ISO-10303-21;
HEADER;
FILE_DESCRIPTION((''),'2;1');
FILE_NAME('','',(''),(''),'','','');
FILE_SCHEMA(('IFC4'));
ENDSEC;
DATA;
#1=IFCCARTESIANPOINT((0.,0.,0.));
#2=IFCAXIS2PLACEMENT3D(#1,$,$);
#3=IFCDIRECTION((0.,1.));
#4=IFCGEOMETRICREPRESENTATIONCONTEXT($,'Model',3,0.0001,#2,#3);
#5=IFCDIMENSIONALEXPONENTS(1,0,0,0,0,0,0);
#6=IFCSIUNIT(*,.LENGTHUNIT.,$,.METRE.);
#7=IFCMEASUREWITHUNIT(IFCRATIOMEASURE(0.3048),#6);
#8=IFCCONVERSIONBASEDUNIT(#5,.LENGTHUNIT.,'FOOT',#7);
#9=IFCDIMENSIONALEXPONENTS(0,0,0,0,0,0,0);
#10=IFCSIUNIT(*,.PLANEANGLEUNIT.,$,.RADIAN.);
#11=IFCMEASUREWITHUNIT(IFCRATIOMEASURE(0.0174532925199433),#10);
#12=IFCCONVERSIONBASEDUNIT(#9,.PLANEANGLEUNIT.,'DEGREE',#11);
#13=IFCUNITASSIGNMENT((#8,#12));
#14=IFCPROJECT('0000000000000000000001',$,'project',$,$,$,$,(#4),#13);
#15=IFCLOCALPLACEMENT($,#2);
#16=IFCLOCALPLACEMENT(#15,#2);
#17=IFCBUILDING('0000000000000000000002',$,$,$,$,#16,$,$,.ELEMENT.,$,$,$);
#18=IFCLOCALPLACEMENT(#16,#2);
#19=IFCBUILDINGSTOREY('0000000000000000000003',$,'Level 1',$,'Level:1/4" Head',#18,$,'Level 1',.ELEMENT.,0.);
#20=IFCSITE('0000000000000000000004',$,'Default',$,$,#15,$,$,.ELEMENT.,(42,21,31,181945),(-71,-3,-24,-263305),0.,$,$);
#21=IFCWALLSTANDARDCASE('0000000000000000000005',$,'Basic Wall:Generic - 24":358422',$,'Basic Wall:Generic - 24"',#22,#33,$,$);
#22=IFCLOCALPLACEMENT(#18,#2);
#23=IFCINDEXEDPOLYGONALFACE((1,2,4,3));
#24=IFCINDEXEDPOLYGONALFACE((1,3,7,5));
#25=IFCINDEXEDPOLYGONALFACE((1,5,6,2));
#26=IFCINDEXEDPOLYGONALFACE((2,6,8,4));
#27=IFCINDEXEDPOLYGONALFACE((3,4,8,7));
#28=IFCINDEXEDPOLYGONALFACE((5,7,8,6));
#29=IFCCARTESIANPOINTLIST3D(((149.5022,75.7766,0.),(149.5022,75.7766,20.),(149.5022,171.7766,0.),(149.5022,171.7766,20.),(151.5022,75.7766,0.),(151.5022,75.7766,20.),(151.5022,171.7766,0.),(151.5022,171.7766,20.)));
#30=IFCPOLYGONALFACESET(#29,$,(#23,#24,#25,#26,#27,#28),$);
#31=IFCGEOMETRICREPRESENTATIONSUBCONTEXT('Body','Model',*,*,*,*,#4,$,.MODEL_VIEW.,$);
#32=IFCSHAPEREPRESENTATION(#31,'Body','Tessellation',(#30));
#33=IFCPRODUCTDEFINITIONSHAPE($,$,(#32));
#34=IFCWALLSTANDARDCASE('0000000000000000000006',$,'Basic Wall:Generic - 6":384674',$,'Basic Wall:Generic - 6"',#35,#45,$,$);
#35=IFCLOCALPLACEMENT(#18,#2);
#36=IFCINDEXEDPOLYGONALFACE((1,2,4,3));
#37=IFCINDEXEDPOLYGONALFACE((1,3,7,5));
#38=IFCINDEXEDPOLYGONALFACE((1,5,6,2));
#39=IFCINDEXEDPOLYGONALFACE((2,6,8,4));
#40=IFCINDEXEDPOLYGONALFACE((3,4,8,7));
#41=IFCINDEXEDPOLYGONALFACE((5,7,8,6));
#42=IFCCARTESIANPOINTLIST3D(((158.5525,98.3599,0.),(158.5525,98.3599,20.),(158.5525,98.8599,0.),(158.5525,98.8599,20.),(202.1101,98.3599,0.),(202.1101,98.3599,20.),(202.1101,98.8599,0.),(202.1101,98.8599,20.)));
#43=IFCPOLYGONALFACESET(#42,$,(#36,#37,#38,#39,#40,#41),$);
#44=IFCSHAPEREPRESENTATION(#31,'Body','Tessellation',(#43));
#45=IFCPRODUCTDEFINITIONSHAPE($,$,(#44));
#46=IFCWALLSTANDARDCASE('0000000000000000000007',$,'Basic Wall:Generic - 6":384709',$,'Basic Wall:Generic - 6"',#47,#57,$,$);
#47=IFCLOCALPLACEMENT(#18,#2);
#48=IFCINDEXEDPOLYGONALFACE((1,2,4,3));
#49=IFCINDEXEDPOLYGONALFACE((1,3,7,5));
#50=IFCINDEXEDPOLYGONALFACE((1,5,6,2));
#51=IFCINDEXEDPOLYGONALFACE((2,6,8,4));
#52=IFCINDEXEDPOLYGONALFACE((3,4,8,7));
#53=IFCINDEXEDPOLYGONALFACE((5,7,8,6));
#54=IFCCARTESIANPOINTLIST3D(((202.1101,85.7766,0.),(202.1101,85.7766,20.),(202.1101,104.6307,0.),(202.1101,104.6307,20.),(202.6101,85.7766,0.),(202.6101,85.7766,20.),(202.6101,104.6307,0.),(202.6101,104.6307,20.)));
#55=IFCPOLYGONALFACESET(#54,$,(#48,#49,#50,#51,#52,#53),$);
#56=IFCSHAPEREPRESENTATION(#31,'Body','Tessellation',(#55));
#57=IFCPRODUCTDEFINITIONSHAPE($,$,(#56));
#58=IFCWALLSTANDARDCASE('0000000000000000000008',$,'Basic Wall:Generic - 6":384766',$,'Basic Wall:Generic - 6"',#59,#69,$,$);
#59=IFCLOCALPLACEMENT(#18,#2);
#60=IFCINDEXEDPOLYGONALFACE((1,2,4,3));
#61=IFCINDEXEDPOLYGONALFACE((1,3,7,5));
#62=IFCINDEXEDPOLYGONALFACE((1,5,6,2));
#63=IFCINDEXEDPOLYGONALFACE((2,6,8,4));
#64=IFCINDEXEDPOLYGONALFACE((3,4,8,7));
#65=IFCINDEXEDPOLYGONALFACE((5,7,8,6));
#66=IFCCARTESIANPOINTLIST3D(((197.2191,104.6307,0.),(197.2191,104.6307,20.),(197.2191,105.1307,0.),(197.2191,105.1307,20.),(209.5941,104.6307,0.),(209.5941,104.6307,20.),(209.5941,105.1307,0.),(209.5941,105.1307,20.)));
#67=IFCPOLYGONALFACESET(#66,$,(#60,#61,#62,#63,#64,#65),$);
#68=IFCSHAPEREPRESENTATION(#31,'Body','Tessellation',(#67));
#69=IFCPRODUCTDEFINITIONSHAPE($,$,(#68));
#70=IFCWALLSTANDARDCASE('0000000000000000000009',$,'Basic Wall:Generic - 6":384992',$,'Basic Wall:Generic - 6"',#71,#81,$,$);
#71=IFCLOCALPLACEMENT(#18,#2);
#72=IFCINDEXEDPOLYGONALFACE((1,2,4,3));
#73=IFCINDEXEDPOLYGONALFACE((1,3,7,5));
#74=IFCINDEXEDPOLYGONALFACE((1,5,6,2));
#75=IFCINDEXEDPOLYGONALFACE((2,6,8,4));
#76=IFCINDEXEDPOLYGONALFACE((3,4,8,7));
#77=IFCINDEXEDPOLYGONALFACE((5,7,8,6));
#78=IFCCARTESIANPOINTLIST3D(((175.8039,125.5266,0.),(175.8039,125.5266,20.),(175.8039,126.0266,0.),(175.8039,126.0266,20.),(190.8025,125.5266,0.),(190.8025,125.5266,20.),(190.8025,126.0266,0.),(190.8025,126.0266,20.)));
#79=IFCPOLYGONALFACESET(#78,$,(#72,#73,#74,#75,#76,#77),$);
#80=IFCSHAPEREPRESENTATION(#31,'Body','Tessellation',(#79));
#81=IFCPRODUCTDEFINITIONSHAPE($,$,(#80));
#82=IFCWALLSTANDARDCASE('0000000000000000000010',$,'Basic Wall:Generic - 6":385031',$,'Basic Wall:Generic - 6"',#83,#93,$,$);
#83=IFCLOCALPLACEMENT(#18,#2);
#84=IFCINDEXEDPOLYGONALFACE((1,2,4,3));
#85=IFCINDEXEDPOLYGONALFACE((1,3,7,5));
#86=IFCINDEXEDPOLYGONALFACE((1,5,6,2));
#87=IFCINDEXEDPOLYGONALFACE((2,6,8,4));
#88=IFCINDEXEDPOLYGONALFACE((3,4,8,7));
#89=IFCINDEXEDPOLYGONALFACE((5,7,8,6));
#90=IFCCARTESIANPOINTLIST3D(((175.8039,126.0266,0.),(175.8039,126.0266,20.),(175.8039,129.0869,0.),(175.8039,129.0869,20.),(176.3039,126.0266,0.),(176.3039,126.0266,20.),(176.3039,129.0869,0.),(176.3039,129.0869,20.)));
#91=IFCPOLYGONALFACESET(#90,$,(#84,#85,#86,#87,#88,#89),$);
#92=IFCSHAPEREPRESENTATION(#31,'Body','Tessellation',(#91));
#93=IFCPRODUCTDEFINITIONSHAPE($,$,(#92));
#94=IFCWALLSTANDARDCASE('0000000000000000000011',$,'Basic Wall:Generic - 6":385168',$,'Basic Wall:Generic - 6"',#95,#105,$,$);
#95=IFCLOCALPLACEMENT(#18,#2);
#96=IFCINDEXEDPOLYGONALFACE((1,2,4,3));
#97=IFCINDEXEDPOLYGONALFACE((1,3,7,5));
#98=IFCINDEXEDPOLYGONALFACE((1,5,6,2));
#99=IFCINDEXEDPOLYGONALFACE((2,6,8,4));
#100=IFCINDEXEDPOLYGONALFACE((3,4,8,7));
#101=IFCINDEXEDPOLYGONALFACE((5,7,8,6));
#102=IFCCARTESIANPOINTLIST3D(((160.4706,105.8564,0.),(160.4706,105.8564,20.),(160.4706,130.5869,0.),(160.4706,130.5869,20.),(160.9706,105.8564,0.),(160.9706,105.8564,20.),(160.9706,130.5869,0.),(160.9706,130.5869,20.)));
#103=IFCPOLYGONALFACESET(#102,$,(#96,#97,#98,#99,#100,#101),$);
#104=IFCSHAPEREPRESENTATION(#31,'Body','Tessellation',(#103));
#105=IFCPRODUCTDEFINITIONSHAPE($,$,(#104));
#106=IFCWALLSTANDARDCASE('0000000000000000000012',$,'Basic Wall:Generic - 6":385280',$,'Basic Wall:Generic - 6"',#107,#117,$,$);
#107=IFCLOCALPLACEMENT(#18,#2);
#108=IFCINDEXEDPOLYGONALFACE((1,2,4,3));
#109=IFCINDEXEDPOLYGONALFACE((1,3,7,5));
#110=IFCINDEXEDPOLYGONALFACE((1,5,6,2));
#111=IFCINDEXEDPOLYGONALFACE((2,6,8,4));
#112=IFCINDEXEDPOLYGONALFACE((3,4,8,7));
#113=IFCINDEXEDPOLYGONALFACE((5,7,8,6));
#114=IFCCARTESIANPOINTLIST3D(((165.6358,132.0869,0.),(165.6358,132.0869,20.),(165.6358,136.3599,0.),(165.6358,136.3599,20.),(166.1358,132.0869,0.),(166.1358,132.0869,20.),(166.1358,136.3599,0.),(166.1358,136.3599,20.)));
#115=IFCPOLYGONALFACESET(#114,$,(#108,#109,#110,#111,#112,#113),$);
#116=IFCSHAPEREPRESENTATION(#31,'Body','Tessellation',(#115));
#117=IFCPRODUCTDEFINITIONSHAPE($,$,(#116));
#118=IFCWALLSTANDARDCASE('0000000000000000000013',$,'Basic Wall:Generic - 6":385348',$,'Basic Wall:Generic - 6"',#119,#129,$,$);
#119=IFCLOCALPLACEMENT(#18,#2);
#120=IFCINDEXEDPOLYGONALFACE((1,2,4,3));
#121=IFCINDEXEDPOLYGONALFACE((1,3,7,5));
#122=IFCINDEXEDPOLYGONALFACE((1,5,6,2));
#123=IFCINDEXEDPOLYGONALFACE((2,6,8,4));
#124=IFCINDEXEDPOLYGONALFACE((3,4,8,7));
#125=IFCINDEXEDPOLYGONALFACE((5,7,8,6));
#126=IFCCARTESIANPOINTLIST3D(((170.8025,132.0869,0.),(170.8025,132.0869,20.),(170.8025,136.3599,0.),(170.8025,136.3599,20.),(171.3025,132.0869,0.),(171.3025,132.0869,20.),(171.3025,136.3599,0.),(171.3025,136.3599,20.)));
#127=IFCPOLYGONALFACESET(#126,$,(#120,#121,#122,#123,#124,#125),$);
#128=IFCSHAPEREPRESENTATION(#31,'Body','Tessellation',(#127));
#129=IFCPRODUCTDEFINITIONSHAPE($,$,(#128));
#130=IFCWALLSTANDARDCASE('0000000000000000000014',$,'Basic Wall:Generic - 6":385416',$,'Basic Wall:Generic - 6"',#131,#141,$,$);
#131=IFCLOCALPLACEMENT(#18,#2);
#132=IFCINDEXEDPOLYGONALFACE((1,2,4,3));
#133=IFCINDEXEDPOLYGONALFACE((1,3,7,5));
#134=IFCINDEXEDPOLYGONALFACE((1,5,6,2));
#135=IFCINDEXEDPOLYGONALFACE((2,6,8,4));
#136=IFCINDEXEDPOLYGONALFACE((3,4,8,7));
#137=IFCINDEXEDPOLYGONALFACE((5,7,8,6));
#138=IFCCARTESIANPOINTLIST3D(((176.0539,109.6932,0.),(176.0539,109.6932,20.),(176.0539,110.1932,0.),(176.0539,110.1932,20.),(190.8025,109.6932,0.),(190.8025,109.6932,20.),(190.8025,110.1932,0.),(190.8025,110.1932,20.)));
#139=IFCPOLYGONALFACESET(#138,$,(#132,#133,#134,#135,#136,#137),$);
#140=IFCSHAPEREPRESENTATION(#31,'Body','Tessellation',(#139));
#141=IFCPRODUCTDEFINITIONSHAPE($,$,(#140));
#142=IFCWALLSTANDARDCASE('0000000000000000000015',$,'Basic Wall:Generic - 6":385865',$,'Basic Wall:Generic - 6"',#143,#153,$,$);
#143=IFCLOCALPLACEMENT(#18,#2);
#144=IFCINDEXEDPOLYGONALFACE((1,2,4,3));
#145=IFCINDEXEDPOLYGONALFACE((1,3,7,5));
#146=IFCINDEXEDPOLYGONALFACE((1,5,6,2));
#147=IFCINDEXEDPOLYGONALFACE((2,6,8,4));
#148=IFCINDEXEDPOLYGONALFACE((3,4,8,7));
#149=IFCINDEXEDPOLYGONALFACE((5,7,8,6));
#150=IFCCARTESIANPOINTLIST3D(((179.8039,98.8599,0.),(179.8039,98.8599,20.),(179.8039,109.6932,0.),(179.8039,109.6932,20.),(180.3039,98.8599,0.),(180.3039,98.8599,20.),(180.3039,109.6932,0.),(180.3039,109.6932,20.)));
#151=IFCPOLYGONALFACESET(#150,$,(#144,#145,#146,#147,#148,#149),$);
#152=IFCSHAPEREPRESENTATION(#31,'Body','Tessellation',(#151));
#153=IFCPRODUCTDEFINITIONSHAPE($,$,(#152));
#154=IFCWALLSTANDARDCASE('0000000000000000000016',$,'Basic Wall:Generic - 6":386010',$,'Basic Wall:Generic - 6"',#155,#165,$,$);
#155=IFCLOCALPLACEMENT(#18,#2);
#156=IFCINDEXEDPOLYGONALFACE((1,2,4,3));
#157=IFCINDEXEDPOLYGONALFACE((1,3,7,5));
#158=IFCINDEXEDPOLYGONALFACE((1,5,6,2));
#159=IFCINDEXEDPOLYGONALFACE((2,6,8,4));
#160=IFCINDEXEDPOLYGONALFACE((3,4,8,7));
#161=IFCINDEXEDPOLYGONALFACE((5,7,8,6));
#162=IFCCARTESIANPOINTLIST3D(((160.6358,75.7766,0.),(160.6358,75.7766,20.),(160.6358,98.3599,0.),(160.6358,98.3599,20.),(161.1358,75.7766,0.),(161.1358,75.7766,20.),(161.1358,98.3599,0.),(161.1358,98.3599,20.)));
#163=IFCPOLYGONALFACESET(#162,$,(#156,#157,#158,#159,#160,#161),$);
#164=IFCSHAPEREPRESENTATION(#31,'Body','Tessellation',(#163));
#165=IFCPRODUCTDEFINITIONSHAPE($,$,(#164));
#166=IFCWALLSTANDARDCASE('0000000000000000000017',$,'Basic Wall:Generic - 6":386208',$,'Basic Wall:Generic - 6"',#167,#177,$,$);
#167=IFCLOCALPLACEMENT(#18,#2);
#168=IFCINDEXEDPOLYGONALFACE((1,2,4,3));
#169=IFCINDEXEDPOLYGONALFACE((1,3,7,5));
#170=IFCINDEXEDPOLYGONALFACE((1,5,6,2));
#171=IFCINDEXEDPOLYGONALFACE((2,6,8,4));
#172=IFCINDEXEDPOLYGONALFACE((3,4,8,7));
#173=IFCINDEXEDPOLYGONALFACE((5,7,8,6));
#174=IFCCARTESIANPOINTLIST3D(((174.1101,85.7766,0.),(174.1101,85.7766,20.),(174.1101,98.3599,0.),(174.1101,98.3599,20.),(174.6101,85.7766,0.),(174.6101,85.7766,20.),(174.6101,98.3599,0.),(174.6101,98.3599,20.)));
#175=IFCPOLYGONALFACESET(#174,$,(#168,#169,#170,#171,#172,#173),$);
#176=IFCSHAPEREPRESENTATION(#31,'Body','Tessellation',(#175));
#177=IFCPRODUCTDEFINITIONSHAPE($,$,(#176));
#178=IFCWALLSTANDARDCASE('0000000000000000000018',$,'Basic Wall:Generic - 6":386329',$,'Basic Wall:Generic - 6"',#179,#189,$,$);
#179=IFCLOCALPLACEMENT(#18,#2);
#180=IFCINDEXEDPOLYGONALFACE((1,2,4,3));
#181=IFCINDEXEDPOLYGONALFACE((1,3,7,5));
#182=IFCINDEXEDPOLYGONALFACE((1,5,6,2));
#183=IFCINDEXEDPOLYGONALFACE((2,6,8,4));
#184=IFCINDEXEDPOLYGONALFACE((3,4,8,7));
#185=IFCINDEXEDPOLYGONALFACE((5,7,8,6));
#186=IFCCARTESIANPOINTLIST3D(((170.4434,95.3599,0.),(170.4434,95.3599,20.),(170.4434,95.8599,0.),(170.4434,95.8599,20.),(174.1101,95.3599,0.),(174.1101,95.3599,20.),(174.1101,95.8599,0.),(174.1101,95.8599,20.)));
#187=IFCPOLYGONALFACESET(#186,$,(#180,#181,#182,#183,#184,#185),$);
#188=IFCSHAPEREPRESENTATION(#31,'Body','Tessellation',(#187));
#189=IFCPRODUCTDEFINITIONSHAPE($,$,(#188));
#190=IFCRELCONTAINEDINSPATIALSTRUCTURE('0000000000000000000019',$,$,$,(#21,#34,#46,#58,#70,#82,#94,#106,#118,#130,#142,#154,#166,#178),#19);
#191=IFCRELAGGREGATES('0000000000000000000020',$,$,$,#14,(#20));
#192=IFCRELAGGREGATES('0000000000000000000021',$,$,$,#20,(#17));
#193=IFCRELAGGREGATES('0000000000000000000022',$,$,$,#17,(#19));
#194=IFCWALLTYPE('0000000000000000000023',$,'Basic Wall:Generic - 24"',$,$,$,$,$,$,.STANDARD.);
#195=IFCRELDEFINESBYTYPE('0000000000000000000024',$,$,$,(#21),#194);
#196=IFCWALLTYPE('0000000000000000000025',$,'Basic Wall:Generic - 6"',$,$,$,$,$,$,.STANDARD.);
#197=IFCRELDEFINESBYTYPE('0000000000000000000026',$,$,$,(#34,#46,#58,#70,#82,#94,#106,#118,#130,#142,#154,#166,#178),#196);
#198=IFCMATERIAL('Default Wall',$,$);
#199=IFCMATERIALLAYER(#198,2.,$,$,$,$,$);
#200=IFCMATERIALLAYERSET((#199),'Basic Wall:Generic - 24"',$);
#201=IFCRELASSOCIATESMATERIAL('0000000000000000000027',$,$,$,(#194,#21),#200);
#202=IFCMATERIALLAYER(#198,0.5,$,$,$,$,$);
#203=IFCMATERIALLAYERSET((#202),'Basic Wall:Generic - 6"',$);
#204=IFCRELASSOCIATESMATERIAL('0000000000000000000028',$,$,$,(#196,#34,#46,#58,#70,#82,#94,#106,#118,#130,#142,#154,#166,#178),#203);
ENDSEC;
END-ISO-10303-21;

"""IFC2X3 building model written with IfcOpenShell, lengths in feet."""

from ifc_helpers import new_model, entity, si_unit, converted_unit, direction, frame, frame_2d, origin, place, context, subcontext, project, spatial, rectangle, extrude, material, layer, layer_set, layer_usage, type_object, element, save


model = new_model("IFC2X3")

# Units and contexts
model_context = context("Model", 3, precision=0.0001, world=origin(), true_north=direction((0.0, 1.0)))
body_context = subcontext(model_context, "Body", "Model", "MODEL_VIEW")
ifc_project = project(units=[converted_unit("LENGTHUNIT", "FOOT", entity("IfcRatioMeasure", 0.3048), si_unit("LENGTHUNIT", "METRE"), dimensions=[1, 0, 0, 0, 0, 0, 0]), converted_unit("PLANEANGLEUNIT", "DEGREE", entity("IfcRatioMeasure", 0.0174532925199433), si_unit("PLANEANGLEUNIT", "RADIAN"), dimensions=[0, 0, 0, 0, 0, 0, 0])], contexts=[model_context])

# Site, building, storey
site_placement = place(None, origin())
site = spatial("IfcSite", under=ifc_project, at=site_placement, Name="Default", CompositionType="ELEMENT", RefLatitude=(42, 21, 31, 181945), RefLongitude=(-71, -3, -24, -263305), RefElevation=0.0)
building_placement = place(site_placement, origin())
building = spatial("IfcBuilding", under=site, at=building_placement, CompositionType="ELEMENT")
storey_placement = place(building_placement, origin())
storey = spatial("IfcBuildingStorey", under=building, at=storey_placement, Name="Level 1", ObjectType="Level:1/4\" Head", LongName="Level 1", CompositionType="ELEMENT", Elevation=0.0)

# Walls
ifc_material = material(Name="Default Wall")
ifc_layer_1 = layer(ifc_material, 2.0)
ifc_layer_set_1 = layer_set([ifc_layer_1], Name="Basic Wall:Generic - 24\"")
ifc_layer_usage_1 = layer_usage(ifc_layer_set_1, "AXIS2", "NEGATIVE", 1.0)
wall_type_1 = type_object("IfcWallType", Name="Basic Wall:Generic - 24\"", PredefinedType="STANDARD", material=ifc_layer_set_1)
wall_1_placement = place(storey_placement, frame((150.5022, 75.7766, 0.0), z_axis=(0.0, 0.0, 1.0), x_axis=(0.0, 1.0, 0.0)))
element("IfcWallStandardCase", 1, at=wall_1_placement, inside=storey, type_object=wall_type_1, material=ifc_layer_usage_1, Name="Basic Wall:Generic - 24\":358422", ObjectType="Basic Wall:Generic - 24\"", context=body_context, shape_type="SweptSolid", body=[
    extrude(rectangle(XDim=96.0, YDim=2.0, at=frame_2d((48.0, 0.0), x_axis=(-1.0, 0.0))), origin(), (0.0, 0.0, 1.0), 20.0),
])
ifc_layer_2 = layer(ifc_material, 0.5)
ifc_layer_set_2 = layer_set([ifc_layer_2], Name="Basic Wall:Generic - 6\"")
ifc_layer_usage_2 = layer_usage(ifc_layer_set_2, "AXIS2", "NEGATIVE", 0.25)
wall_type_2 = type_object("IfcWallType", Name="Basic Wall:Generic - 6\"", PredefinedType="STANDARD", material=ifc_layer_set_2)
wall_2_placement = place(storey_placement, frame((158.5525, 98.6099, 0.0)))
element("IfcWallStandardCase", 2, at=wall_2_placement, inside=storey, type_object=wall_type_2, material=ifc_layer_usage_2, Name="Basic Wall:Generic - 6\":384674", ObjectType="Basic Wall:Generic - 6\"", context=body_context, shape_type="SweptSolid", body=[
    extrude(rectangle(XDim=43.5576, YDim=0.5, at=frame_2d((21.7788, 0.0), x_axis=(-1.0, 0.0))), origin(), (0.0, 0.0, 1.0), 20.0),
])
ifc_layer_usage_3 = layer_usage(ifc_layer_set_2, "AXIS2", "NEGATIVE", 0.25)
wall_3_placement = place(storey_placement, frame((202.3601, 85.7766, 0.0), z_axis=(0.0, 0.0, 1.0), x_axis=(0.0, 1.0, 0.0)))
element("IfcWallStandardCase", 3, at=wall_3_placement, inside=storey, type_object=wall_type_2, material=ifc_layer_usage_3, Name="Basic Wall:Generic - 6\":384709", ObjectType="Basic Wall:Generic - 6\"", context=body_context, shape_type="SweptSolid", body=[
    extrude(rectangle(XDim=18.8542, YDim=0.5, at=frame_2d((9.4271, 0.0), x_axis=(-1.0, 0.0))), origin(), (0.0, 0.0, 1.0), 20.0),
])
ifc_layer_usage_4 = layer_usage(ifc_layer_set_2, "AXIS2", "NEGATIVE", 0.25)
wall_4_placement = place(storey_placement, frame((197.2191, 104.8807, 0.0)))
element("IfcWallStandardCase", 4, at=wall_4_placement, inside=storey, type_object=wall_type_2, material=ifc_layer_usage_4, Name="Basic Wall:Generic - 6\":384766", ObjectType="Basic Wall:Generic - 6\"", context=body_context, shape_type="SweptSolid", body=[
    extrude(rectangle(XDim=12.375, YDim=0.5, at=frame_2d((6.1875, 0.0), x_axis=(-1.0, 0.0))), origin(), (0.0, 0.0, 1.0), 20.0),
])
ifc_layer_usage_5 = layer_usage(ifc_layer_set_2, "AXIS2", "NEGATIVE", 0.25)
wall_5_placement = place(storey_placement, frame((190.8025, 125.7766, 0.0), z_axis=(0.0, 0.0, 1.0), x_axis=(-1.0, 0.0, 0.0)))
element("IfcWallStandardCase", 5, at=wall_5_placement, inside=storey, type_object=wall_type_2, material=ifc_layer_usage_5, Name="Basic Wall:Generic - 6\":384992", ObjectType="Basic Wall:Generic - 6\"", context=body_context, shape_type="SweptSolid", body=[
    extrude(rectangle(XDim=14.9985, YDim=0.5, at=frame_2d((7.4993, 0.0), x_axis=(-1.0, 0.0))), origin(), (0.0, 0.0, 1.0), 20.0),
])
ifc_layer_usage_6 = layer_usage(ifc_layer_set_2, "AXIS2", "NEGATIVE", 0.25)
wall_6_placement = place(storey_placement, frame((176.0539, 126.0266, 0.0), z_axis=(0.0, 0.0, 1.0), x_axis=(0.0, 1.0, 0.0)))
element("IfcWallStandardCase", 6, at=wall_6_placement, inside=storey, type_object=wall_type_2, material=ifc_layer_usage_6, Name="Basic Wall:Generic - 6\":385031", ObjectType="Basic Wall:Generic - 6\"", context=body_context, shape_type="SweptSolid", body=[
    extrude(rectangle(XDim=3.0603, YDim=0.5, at=frame_2d((1.5302, 0.0), x_axis=(-1.0, 0.0))), origin(), (0.0, 0.0, 1.0), 20.0),
])
ifc_layer_usage_7 = layer_usage(ifc_layer_set_2, "AXIS2", "NEGATIVE", 0.25)
wall_7_placement = place(storey_placement, frame((160.7206, 105.8564, 0.0), z_axis=(0.0, 0.0, 1.0), x_axis=(0.0, 1.0, 0.0)))
element("IfcWallStandardCase", 7, at=wall_7_placement, inside=storey, type_object=wall_type_2, material=ifc_layer_usage_7, Name="Basic Wall:Generic - 6\":385168", ObjectType="Basic Wall:Generic - 6\"", context=body_context, shape_type="SweptSolid", body=[
    extrude(rectangle(XDim=24.7305, YDim=0.5, at=frame_2d((12.3652, 0.0), x_axis=(-1.0, 0.0))), origin(), (0.0, 0.0, 1.0), 20.0),
])
ifc_layer_usage_8 = layer_usage(ifc_layer_set_2, "AXIS2", "NEGATIVE", 0.25)
wall_8_placement = place(storey_placement, frame((165.8858, 136.3599, 0.0), z_axis=(0.0, 0.0, 1.0), x_axis=(0.0, -1.0, 0.0)))
element("IfcWallStandardCase", 8, at=wall_8_placement, inside=storey, type_object=wall_type_2, material=ifc_layer_usage_8, Name="Basic Wall:Generic - 6\":385280", ObjectType="Basic Wall:Generic - 6\"", context=body_context, shape_type="SweptSolid", body=[
    extrude(rectangle(XDim=4.273, YDim=0.5, at=frame_2d((2.1365, 0.0), x_axis=(-1.0, 0.0))), origin(), (0.0, 0.0, 1.0), 20.0),
])
ifc_layer_usage_9 = layer_usage(ifc_layer_set_2, "AXIS2", "NEGATIVE", 0.25)
wall_9_placement = place(storey_placement, frame((171.0525, 132.0869, 0.0), z_axis=(0.0, 0.0, 1.0), x_axis=(0.0, 1.0, 0.0)))
element("IfcWallStandardCase", 9, at=wall_9_placement, inside=storey, type_object=wall_type_2, material=ifc_layer_usage_9, Name="Basic Wall:Generic - 6\":385348", ObjectType="Basic Wall:Generic - 6\"", context=body_context, shape_type="SweptSolid", body=[
    extrude(rectangle(XDim=4.273, YDim=0.5, at=frame_2d((2.1365, 0.0), x_axis=(-1.0, 0.0))), origin(), (0.0, 0.0, 1.0), 20.0),
])
ifc_layer_usage_10 = layer_usage(ifc_layer_set_2, "AXIS2", "NEGATIVE", 0.25)
wall_10_placement = place(storey_placement, frame((176.0539, 109.9432, 0.0)))
element("IfcWallStandardCase", 10, at=wall_10_placement, inside=storey, type_object=wall_type_2, material=ifc_layer_usage_10, Name="Basic Wall:Generic - 6\":385416", ObjectType="Basic Wall:Generic - 6\"", context=body_context, shape_type="SweptSolid", body=[
    extrude(rectangle(XDim=14.7485, YDim=0.5, at=frame_2d((7.3743, 0.0), x_axis=(-1.0, 0.0))), origin(), (0.0, 0.0, 1.0), 20.0),
])
ifc_layer_usage_11 = layer_usage(ifc_layer_set_2, "AXIS2", "NEGATIVE", 0.25)
wall_11_placement = place(storey_placement, frame((180.0539, 109.6932, 0.0), z_axis=(0.0, 0.0, 1.0), x_axis=(0.0, -1.0, 0.0)))
element("IfcWallStandardCase", 11, at=wall_11_placement, inside=storey, type_object=wall_type_2, material=ifc_layer_usage_11, Name="Basic Wall:Generic - 6\":385865", ObjectType="Basic Wall:Generic - 6\"", context=body_context, shape_type="SweptSolid", body=[
    extrude(rectangle(XDim=10.8333, YDim=0.5, at=frame_2d((5.4167, 0.0), x_axis=(-1.0, 0.0))), origin(), (0.0, 0.0, 1.0), 20.0),
])
ifc_layer_usage_12 = layer_usage(ifc_layer_set_2, "AXIS2", "NEGATIVE", 0.25)
wall_12_placement = place(storey_placement, frame((160.8858, 98.3599, 0.0), z_axis=(0.0, 0.0, 1.0), x_axis=(0.0, -1.0, 0.0)))
element("IfcWallStandardCase", 12, at=wall_12_placement, inside=storey, type_object=wall_type_2, material=ifc_layer_usage_12, Name="Basic Wall:Generic - 6\":386010", ObjectType="Basic Wall:Generic - 6\"", context=body_context, shape_type="SweptSolid", body=[
    extrude(rectangle(XDim=22.5833, YDim=0.5, at=frame_2d((11.2917, 0.0), x_axis=(-1.0, 0.0))), origin(), (0.0, 0.0, 1.0), 20.0),
])
ifc_layer_usage_13 = layer_usage(ifc_layer_set_2, "AXIS2", "NEGATIVE", 0.25)
wall_13_placement = place(storey_placement, frame((174.3601, 98.3599, 0.0), z_axis=(0.0, 0.0, 1.0), x_axis=(0.0, -1.0, 0.0)))
element("IfcWallStandardCase", 13, at=wall_13_placement, inside=storey, type_object=wall_type_2, material=ifc_layer_usage_13, Name="Basic Wall:Generic - 6\":386208", ObjectType="Basic Wall:Generic - 6\"", context=body_context, shape_type="SweptSolid", body=[
    extrude(rectangle(XDim=12.5833, YDim=0.5, at=frame_2d((6.2917, 0.0), x_axis=(-1.0, 0.0))), origin(), (0.0, 0.0, 1.0), 20.0),
])
ifc_layer_usage_14 = layer_usage(ifc_layer_set_2, "AXIS2", "NEGATIVE", 0.25)
wall_14_placement = place(storey_placement, frame((174.1101, 95.6099, 0.0), z_axis=(0.0, 0.0, 1.0), x_axis=(-1.0, 0.0, 0.0)))
element("IfcWallStandardCase", 14, at=wall_14_placement, inside=storey, type_object=wall_type_2, material=ifc_layer_usage_14, Name="Basic Wall:Generic - 6\":386329", ObjectType="Basic Wall:Generic - 6\"", context=body_context, shape_type="SweptSolid", body=[
    extrude(rectangle(XDim=3.6667, YDim=0.5, at=frame_2d((1.8333, 0.0), x_axis=(-1.0, 0.0))), origin(), (0.0, 0.0, 1.0), 20.0),
])

save(model, "model.ifc")
